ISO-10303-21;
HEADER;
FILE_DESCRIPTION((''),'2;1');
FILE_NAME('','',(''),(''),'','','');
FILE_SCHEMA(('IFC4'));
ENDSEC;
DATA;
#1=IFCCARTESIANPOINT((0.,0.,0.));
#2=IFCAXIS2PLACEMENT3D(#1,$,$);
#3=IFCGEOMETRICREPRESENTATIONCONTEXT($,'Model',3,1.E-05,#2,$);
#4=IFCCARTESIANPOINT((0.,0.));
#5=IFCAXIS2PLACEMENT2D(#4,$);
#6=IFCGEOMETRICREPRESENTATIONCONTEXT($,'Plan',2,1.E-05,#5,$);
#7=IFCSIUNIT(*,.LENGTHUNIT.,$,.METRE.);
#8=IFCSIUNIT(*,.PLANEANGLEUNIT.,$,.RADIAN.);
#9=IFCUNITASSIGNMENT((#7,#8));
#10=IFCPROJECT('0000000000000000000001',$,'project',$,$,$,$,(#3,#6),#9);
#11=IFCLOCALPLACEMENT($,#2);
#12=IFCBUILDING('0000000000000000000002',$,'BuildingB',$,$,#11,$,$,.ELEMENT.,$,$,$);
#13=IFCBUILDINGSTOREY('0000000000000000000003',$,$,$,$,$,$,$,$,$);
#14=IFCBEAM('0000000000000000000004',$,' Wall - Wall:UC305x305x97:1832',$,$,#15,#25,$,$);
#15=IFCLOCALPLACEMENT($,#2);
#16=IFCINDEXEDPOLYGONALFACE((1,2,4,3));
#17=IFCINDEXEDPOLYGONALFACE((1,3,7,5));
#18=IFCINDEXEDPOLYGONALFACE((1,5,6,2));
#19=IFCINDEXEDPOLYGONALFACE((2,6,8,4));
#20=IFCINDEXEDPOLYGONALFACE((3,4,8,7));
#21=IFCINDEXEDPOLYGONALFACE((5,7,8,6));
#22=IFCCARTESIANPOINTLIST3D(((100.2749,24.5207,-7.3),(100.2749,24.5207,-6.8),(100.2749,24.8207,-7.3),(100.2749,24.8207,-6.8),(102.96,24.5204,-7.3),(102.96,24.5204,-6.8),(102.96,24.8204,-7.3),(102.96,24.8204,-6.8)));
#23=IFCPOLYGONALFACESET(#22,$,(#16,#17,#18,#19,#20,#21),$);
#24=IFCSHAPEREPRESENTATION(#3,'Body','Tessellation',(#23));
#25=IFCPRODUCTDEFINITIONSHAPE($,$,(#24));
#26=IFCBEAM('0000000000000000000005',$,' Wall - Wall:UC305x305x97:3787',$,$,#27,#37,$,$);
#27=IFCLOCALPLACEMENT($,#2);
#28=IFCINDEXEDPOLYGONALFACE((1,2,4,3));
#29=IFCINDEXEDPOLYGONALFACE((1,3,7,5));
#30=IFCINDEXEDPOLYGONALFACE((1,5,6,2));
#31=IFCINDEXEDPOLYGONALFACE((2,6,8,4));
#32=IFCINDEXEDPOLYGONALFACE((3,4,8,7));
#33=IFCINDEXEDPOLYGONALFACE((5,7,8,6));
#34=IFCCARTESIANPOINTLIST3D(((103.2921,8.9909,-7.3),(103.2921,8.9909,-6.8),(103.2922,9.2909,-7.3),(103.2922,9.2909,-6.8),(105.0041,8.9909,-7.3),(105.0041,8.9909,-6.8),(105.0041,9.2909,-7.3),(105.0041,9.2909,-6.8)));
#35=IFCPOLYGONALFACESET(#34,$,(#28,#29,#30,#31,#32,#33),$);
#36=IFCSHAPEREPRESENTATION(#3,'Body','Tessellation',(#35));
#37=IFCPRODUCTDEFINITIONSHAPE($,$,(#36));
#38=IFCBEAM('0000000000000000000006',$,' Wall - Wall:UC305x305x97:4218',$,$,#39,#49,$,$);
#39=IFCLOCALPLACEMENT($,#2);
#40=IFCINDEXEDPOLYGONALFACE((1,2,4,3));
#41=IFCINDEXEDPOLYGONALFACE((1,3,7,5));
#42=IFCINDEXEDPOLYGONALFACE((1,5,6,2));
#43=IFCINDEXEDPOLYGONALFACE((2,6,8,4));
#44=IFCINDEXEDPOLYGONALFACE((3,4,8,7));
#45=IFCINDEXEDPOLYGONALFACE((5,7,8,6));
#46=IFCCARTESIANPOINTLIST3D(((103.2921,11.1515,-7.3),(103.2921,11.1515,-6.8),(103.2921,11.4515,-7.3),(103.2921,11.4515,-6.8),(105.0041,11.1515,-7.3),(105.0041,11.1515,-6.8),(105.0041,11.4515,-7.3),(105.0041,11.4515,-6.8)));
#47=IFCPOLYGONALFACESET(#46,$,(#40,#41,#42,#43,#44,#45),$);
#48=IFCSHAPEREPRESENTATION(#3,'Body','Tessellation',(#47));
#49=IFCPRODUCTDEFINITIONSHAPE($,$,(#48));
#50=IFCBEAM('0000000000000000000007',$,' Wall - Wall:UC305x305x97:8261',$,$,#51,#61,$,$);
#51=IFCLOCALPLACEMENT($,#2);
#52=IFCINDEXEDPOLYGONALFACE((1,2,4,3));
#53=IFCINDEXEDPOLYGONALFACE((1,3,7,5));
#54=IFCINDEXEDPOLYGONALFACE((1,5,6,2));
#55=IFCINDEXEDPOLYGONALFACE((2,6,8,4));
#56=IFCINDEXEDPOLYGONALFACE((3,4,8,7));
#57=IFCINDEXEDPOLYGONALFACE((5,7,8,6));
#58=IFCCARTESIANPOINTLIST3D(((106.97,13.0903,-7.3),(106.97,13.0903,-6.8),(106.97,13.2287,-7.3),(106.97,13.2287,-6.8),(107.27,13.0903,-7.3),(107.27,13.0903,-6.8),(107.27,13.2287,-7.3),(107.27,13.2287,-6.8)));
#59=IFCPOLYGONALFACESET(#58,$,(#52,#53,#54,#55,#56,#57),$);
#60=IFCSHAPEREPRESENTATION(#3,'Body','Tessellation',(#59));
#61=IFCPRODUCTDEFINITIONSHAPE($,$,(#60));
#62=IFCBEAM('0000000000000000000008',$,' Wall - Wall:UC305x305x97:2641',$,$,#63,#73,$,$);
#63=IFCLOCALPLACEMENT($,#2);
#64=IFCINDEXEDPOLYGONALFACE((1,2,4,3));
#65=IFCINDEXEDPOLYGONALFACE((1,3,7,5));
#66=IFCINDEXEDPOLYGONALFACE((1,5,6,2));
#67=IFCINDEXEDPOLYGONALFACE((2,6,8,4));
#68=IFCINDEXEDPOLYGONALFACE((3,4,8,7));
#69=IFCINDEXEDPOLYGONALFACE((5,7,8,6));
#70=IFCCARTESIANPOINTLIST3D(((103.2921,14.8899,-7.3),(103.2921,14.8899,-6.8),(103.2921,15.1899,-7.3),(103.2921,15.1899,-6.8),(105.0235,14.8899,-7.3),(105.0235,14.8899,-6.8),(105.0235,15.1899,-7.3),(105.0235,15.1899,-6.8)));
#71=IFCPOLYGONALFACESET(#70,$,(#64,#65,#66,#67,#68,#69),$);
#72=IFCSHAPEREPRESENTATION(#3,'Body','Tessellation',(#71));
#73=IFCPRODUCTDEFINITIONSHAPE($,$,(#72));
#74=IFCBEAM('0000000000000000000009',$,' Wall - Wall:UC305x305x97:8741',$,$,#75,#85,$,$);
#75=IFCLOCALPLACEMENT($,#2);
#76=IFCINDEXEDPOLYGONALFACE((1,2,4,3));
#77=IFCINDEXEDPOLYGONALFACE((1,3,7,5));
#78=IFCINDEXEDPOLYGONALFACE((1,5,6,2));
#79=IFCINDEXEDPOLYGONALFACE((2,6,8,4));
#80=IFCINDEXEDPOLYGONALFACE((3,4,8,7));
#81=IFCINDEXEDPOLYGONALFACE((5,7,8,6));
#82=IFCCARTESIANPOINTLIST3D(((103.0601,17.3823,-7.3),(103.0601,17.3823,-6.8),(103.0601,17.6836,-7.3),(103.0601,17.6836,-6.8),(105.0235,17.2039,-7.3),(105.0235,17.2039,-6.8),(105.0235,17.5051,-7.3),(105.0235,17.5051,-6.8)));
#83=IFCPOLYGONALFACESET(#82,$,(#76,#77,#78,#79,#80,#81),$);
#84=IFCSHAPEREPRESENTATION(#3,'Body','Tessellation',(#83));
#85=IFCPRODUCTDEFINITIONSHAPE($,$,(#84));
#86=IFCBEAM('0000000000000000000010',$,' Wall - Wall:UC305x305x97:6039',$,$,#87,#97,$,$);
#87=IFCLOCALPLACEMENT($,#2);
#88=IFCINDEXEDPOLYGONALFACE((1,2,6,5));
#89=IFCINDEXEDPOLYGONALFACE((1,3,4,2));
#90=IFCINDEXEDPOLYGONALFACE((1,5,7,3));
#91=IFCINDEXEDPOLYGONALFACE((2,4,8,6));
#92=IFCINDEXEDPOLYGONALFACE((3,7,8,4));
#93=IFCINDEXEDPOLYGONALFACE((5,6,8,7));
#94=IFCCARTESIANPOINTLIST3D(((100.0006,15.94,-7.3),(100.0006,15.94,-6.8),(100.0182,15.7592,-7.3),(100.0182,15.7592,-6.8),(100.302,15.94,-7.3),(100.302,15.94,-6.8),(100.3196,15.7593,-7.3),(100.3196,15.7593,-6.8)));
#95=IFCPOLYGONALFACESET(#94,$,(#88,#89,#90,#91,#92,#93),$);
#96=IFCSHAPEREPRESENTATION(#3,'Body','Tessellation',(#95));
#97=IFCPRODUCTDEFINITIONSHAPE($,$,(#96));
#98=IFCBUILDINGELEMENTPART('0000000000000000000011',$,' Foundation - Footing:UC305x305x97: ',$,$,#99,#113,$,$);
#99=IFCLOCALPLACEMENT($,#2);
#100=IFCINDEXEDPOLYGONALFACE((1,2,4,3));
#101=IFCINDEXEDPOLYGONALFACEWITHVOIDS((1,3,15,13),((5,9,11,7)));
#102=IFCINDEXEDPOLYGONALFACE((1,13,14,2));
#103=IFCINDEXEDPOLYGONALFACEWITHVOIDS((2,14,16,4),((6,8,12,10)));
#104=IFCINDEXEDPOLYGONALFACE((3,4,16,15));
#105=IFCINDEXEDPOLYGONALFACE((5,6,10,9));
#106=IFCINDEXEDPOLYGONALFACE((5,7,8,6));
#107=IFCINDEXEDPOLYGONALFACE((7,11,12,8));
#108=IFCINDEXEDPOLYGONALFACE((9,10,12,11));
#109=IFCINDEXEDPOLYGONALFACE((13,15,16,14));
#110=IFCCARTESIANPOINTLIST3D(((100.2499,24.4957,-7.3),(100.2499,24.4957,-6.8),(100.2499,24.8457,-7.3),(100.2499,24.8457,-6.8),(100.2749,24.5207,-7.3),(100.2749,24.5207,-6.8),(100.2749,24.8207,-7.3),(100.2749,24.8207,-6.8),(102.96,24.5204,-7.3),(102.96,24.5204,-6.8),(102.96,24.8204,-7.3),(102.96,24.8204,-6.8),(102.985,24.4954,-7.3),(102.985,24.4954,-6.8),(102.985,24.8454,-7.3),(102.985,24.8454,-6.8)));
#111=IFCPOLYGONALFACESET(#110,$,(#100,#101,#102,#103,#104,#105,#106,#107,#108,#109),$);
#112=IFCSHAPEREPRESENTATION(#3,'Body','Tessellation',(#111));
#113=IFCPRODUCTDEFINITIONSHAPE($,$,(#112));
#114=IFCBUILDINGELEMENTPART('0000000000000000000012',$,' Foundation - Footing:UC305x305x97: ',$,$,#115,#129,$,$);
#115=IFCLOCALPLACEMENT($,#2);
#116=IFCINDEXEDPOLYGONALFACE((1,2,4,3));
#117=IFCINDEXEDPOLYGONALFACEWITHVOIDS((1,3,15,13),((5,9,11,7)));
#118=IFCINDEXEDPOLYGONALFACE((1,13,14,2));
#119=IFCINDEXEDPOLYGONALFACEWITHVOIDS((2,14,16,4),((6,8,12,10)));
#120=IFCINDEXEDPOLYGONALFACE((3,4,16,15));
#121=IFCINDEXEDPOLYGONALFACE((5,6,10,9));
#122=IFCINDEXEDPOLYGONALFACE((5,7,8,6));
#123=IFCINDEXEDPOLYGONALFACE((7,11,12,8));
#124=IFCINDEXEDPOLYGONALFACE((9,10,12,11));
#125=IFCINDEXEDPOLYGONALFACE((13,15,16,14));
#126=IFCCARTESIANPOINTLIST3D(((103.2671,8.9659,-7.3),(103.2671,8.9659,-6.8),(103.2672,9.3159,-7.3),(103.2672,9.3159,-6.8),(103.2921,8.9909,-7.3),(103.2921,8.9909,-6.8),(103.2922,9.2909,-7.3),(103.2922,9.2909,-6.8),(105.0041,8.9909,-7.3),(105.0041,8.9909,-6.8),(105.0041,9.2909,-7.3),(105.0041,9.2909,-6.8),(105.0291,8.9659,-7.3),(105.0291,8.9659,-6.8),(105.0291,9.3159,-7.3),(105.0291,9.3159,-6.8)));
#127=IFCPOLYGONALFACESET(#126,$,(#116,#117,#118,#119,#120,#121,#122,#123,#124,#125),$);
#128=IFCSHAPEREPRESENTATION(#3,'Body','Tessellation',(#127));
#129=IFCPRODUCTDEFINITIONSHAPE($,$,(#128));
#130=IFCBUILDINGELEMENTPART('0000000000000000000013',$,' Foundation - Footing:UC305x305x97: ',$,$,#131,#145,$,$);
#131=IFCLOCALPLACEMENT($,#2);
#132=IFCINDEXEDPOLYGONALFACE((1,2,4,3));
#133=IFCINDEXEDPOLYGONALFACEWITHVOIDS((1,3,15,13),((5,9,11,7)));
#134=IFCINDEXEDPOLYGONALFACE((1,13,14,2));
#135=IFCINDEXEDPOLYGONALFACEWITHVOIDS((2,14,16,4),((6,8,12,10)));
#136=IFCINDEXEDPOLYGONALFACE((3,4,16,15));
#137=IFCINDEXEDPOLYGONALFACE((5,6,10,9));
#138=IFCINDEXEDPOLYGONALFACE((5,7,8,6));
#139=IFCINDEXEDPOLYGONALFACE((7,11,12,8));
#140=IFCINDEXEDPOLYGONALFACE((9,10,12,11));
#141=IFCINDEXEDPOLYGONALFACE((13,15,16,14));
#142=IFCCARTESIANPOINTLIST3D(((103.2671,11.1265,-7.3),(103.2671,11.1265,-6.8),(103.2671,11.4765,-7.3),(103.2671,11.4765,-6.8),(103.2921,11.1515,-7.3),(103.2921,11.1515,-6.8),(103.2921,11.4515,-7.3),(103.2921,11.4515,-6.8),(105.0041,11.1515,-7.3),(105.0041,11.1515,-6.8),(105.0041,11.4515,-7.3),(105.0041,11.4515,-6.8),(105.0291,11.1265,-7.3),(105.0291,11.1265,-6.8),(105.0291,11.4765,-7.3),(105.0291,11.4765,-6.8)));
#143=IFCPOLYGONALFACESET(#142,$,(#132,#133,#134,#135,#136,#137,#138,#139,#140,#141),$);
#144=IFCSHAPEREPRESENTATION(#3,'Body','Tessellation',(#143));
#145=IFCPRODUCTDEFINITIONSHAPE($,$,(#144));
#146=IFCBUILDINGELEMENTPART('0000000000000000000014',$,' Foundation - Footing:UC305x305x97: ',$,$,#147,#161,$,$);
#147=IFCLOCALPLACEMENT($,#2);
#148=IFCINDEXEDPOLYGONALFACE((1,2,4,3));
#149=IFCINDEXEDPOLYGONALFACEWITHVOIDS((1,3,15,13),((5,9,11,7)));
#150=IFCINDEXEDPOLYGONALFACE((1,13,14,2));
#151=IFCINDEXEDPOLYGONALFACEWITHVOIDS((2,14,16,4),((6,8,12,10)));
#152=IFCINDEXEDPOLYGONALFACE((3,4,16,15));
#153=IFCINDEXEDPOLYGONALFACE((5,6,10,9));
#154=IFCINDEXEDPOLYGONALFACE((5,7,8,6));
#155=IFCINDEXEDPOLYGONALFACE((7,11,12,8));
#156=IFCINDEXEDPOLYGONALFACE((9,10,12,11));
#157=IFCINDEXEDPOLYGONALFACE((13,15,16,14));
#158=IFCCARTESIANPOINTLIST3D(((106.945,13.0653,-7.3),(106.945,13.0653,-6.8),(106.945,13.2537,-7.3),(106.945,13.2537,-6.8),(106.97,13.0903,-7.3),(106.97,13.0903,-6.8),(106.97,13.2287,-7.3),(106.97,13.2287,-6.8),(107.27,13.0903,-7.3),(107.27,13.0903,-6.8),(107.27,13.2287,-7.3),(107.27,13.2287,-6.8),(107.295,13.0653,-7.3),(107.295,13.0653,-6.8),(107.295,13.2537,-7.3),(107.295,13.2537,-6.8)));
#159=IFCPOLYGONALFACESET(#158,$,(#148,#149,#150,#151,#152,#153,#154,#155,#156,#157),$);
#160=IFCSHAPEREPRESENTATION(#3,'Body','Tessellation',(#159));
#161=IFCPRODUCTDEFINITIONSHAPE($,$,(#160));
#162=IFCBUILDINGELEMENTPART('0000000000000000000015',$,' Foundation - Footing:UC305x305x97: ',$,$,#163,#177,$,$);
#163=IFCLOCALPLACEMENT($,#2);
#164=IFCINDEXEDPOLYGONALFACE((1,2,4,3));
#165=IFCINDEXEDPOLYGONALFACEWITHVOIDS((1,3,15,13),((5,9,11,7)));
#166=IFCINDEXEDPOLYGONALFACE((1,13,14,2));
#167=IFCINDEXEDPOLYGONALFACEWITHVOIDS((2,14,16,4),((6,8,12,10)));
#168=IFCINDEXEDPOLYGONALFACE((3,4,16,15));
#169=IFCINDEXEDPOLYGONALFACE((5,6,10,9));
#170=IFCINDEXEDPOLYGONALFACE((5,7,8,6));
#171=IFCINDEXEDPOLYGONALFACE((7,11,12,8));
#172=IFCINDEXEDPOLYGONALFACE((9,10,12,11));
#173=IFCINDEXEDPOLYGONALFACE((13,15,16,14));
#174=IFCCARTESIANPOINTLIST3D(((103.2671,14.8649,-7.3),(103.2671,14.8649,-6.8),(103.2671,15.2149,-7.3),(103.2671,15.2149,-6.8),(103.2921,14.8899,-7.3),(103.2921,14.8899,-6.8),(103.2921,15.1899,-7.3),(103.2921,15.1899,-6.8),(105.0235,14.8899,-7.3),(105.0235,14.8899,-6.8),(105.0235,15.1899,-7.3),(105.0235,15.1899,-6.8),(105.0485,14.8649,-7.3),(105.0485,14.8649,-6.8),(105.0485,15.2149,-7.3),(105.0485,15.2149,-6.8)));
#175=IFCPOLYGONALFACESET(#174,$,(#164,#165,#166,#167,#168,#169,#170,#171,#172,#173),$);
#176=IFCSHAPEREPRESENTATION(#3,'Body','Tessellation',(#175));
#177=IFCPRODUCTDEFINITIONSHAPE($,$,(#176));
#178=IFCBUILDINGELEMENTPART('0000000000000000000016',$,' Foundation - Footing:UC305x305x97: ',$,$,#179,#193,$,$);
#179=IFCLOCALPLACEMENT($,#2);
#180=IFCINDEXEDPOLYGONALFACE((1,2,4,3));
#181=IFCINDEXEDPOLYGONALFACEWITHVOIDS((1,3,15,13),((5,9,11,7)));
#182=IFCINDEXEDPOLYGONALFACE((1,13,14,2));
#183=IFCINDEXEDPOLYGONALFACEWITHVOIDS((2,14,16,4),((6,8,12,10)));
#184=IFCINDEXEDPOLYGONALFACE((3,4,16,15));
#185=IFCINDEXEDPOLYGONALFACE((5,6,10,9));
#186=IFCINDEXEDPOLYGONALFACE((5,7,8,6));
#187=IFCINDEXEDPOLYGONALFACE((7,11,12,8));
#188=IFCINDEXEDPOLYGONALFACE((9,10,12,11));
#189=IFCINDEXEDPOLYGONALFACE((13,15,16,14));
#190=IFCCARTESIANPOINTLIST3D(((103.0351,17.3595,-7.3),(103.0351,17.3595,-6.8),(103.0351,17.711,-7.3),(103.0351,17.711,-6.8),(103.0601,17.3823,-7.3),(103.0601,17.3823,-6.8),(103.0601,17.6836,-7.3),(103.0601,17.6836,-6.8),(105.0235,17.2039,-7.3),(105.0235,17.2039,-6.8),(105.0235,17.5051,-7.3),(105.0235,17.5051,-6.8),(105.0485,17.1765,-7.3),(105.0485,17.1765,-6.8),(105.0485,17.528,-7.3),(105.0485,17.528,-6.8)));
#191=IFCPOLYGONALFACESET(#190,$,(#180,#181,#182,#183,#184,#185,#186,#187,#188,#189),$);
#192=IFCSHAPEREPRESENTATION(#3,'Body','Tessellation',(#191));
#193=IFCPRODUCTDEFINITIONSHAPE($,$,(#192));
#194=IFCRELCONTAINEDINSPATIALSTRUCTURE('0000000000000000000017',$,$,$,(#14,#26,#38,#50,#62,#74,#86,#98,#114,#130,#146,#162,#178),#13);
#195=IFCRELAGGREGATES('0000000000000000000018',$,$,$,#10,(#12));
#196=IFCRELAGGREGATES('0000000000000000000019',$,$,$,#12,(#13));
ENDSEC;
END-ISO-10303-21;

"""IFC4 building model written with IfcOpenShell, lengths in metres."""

from ifc_helpers import new_model, si_unit, origin, origin_2d, place, context, project, spatial, polyline, outline, extrude, element, save


model = new_model("IFC4")

# Units and contexts
model_context = context("Model", 3, precision=1e-05, world=origin())
plan_context = context("Plan", 2, precision=1e-05, world=origin_2d())
ifc_project = project(units=[si_unit("LENGTHUNIT", "METRE"), si_unit("PLANEANGLEUNIT", "RADIAN")], contexts=[model_context, plan_context])

# Building, storey
building_placement = place(None, origin())
building = spatial("IfcBuilding", under=ifc_project, at=building_placement, Name="BuildingB", CompositionType="ELEMENT")
storey = spatial("IfcBuildingStorey", under=building)

# Beams
element("IfcBeam", 1, inside=storey, Name=" Wall - Wall:UC305x305x97:1832", context=model_context, shape_type="SweptSolid", body=[
    extrude(outline(polyline([(102.96, 24.5204, -7.3), (102.96, 24.8204, -7.3), (100.2749, 24.8207, -7.3), (100.2749, 24.5207, -7.3), (102.96, 24.5204, -7.3)])), None, (0.0, 0.0, 1.0), 0.5),
])
element("IfcBeam", 2, inside=storey, Name=" Wall - Wall:UC305x305x97:3787", context=model_context, shape_type="SweptSolid", body=[
    extrude(outline(polyline([(105.0041, 8.9909, -7.3), (105.0041, 9.2909, -7.3), (103.2922, 9.2909, -7.3), (103.2921, 8.9909, -7.3), (105.0041, 8.9909, -7.3)])), None, (0.0, 0.0, 1.0), 0.5),
])
element("IfcBeam", 3, inside=storey, Name=" Wall - Wall:UC305x305x97:4218", context=model_context, shape_type="SweptSolid", body=[
    extrude(outline(polyline([(105.0041, 11.1515, -7.3), (105.0041, 11.4515, -7.3), (103.2921, 11.4515, -7.3), (103.2921, 11.1515, -7.3), (105.0041, 11.1515, -7.3)])), None, (0.0, 0.0, 1.0), 0.5),
])
element("IfcBeam", 4, inside=storey, Name=" Wall - Wall:UC305x305x97:8261", context=model_context, shape_type="SweptSolid", body=[
    extrude(outline(polyline([(107.27, 13.0903, -7.3), (107.27, 13.2287, -7.3), (106.97, 13.2287, -7.3), (106.97, 13.0903, -7.3), (107.27, 13.0903, -7.3)])), None, (0.0, 0.0, 1.0), 0.5),
])
element("IfcBeam", 5, inside=storey, Name=" Wall - Wall:UC305x305x97:2641", context=model_context, shape_type="SweptSolid", body=[
    extrude(outline(polyline([(105.0235, 14.8899, -7.3), (105.0235, 15.1899, -7.3), (103.2921, 15.1899, -7.3), (103.2921, 14.8899, -7.3), (105.0235, 14.8899, -7.3)])), None, (0.0, 0.0, 1.0), 0.5),
])
element("IfcBeam", 6, inside=storey, Name=" Wall - Wall:UC305x305x97:8741", context=model_context, shape_type="SweptSolid", body=[
    extrude(outline(polyline([(105.0235, 17.2039, -7.3), (105.0235, 17.5051, -7.3), (103.0601, 17.6836, -7.3), (103.0601, 17.3823, -7.3), (105.0235, 17.2039, -7.3)])), None, (0.0, 0.0, 1.0), 0.5),
])
element("IfcBeam", 7, inside=storey, Name=" Wall - Wall:UC305x305x97:6039", context=model_context, shape_type="SweptSolid", body=[
    extrude(outline(polyline([(100.3196, 15.7593, -7.3), (100.302, 15.94, -7.3), (100.0006, 15.94, -7.3), (100.0182, 15.7592, -7.3), (100.3196, 15.7593, -7.3)])), None, (0.0, 0.0, 1.0), 0.5),
])

# Building element parts, openings
building_element_part_1 = element("IfcBuildingElementPart", 8, inside=storey, Name=" Foundation - Footing:UC305x305x97: ", context=model_context, shape_type="SweptSolid", body=[
    extrude(outline(polyline([(102.985, 24.4954, -7.3), (102.985, 24.8454, -7.3), (100.2499, 24.8457, -7.3), (100.2499, 24.4957, -7.3), (102.985, 24.4954, -7.3)])), None, (0.0, 0.0, 1.0), 0.5),
])
element("IfcOpeningElement", 9, inside=storey, cuts=building_element_part_1, context=model_context, shape_type="SweptSolid", body=[
    extrude(outline(polyline([(102.96, 24.5204, -7.3), (102.96, 24.8204, -7.3), (100.2749, 24.8207, -7.3), (100.2749, 24.5207, -7.3), (102.96, 24.5204, -7.3)])), None, (0.0, 0.0, 1.0), 0.5),
])
building_element_part_2 = element("IfcBuildingElementPart", 10, inside=storey, Name=" Foundation - Footing:UC305x305x97: ", context=model_context, shape_type="SweptSolid", body=[
    extrude(outline(polyline([(105.0291, 8.9659, -7.3), (105.0291, 9.3159, -7.3), (103.2672, 9.3159, -7.3), (103.2671, 8.9659, -7.3), (105.0291, 8.9659, -7.3)])), None, (0.0, 0.0, 1.0), 0.5),
])
element("IfcOpeningElement", 11, inside=storey, cuts=building_element_part_2, context=model_context, shape_type="SweptSolid", body=[
    extrude(outline(polyline([(105.0041, 8.9909, -7.3), (105.0041, 9.2909, -7.3), (103.2922, 9.2909, -7.3), (103.2921, 8.9909, -7.3), (105.0041, 8.9909, -7.3)])), None, (0.0, 0.0, 1.0), 0.5),
])
building_element_part_3 = element("IfcBuildingElementPart", 12, inside=storey, Name=" Foundation - Footing:UC305x305x97: ", context=model_context, shape_type="SweptSolid", body=[
    extrude(outline(polyline([(105.0291, 11.1265, -7.3), (105.0291, 11.4765, -7.3), (103.2671, 11.4765, -7.3), (103.2671, 11.1265, -7.3), (105.0291, 11.1265, -7.3)])), None, (0.0, 0.0, 1.0), 0.5),
])
element("IfcOpeningElement", 13, inside=storey, cuts=building_element_part_3, context=model_context, shape_type="SweptSolid", body=[
    extrude(outline(polyline([(105.0041, 11.1515, -7.3), (105.0041, 11.4515, -7.3), (103.2921, 11.4515, -7.3), (103.2921, 11.1515, -7.3), (105.0041, 11.1515, -7.3)])), None, (0.0, 0.0, 1.0), 0.5),
])
building_element_part_4 = element("IfcBuildingElementPart", 14, inside=storey, Name=" Foundation - Footing:UC305x305x97: ", context=model_context, shape_type="SweptSolid", body=[
    extrude(outline(polyline([(107.295, 13.0653, -7.3), (107.295, 13.2537, -7.3), (106.945, 13.2537, -7.3), (106.945, 13.0653, -7.3), (107.295, 13.0653, -7.3)])), None, (0.0, 0.0, 1.0), 0.5),
])
element("IfcOpeningElement", 15, inside=storey, cuts=building_element_part_4, context=model_context, shape_type="SweptSolid", body=[
    extrude(outline(polyline([(107.27, 13.0903, -7.3), (107.27, 13.2287, -7.3), (106.97, 13.2287, -7.3), (106.97, 13.0903, -7.3), (107.27, 13.0903, -7.3)])), None, (0.0, 0.0, 1.0), 0.5),
])
building_element_part_5 = element("IfcBuildingElementPart", 16, inside=storey, Name=" Foundation - Footing:UC305x305x97: ", context=model_context, shape_type="SweptSolid", body=[
    extrude(outline(polyline([(105.0485, 14.8649, -7.3), (105.0485, 15.2149, -7.3), (103.2671, 15.2149, -7.3), (103.2671, 14.8649, -7.3), (105.0485, 14.8649, -7.3)])), None, (0.0, 0.0, 1.0), 0.5),
])
element("IfcOpeningElement", 17, inside=storey, cuts=building_element_part_5, context=model_context, shape_type="SweptSolid", body=[
    extrude(outline(polyline([(105.0235, 14.8899, -7.3), (105.0235, 15.1899, -7.3), (103.2921, 15.1899, -7.3), (103.2921, 14.8899, -7.3), (105.0235, 14.8899, -7.3)])), None, (0.0, 0.0, 1.0), 0.5),
])
building_element_part_6 = element("IfcBuildingElementPart", 18, inside=storey, Name=" Foundation - Footing:UC305x305x97: ", context=model_context, shape_type="SweptSolid", body=[
    extrude(outline(polyline([(105.0485, 17.1765, -7.3), (105.0485, 17.528, -7.3), (103.0351, 17.711, -7.3), (103.0351, 17.3595, -7.3), (105.0485, 17.1765, -7.3)])), None, (0.0, 0.0, 1.0), 0.5),
])
element("IfcOpeningElement", 19, inside=storey, cuts=building_element_part_6, context=model_context, shape_type="SweptSolid", body=[
    extrude(outline(polyline([(105.0235, 17.2039, -7.3), (105.0235, 17.5051, -7.3), (103.0601, 17.6836, -7.3), (103.0601, 17.3823, -7.3), (105.0235, 17.2039, -7.3)])), None, (0.0, 0.0, 1.0), 0.5),
])

save(model, "model.ifc")
